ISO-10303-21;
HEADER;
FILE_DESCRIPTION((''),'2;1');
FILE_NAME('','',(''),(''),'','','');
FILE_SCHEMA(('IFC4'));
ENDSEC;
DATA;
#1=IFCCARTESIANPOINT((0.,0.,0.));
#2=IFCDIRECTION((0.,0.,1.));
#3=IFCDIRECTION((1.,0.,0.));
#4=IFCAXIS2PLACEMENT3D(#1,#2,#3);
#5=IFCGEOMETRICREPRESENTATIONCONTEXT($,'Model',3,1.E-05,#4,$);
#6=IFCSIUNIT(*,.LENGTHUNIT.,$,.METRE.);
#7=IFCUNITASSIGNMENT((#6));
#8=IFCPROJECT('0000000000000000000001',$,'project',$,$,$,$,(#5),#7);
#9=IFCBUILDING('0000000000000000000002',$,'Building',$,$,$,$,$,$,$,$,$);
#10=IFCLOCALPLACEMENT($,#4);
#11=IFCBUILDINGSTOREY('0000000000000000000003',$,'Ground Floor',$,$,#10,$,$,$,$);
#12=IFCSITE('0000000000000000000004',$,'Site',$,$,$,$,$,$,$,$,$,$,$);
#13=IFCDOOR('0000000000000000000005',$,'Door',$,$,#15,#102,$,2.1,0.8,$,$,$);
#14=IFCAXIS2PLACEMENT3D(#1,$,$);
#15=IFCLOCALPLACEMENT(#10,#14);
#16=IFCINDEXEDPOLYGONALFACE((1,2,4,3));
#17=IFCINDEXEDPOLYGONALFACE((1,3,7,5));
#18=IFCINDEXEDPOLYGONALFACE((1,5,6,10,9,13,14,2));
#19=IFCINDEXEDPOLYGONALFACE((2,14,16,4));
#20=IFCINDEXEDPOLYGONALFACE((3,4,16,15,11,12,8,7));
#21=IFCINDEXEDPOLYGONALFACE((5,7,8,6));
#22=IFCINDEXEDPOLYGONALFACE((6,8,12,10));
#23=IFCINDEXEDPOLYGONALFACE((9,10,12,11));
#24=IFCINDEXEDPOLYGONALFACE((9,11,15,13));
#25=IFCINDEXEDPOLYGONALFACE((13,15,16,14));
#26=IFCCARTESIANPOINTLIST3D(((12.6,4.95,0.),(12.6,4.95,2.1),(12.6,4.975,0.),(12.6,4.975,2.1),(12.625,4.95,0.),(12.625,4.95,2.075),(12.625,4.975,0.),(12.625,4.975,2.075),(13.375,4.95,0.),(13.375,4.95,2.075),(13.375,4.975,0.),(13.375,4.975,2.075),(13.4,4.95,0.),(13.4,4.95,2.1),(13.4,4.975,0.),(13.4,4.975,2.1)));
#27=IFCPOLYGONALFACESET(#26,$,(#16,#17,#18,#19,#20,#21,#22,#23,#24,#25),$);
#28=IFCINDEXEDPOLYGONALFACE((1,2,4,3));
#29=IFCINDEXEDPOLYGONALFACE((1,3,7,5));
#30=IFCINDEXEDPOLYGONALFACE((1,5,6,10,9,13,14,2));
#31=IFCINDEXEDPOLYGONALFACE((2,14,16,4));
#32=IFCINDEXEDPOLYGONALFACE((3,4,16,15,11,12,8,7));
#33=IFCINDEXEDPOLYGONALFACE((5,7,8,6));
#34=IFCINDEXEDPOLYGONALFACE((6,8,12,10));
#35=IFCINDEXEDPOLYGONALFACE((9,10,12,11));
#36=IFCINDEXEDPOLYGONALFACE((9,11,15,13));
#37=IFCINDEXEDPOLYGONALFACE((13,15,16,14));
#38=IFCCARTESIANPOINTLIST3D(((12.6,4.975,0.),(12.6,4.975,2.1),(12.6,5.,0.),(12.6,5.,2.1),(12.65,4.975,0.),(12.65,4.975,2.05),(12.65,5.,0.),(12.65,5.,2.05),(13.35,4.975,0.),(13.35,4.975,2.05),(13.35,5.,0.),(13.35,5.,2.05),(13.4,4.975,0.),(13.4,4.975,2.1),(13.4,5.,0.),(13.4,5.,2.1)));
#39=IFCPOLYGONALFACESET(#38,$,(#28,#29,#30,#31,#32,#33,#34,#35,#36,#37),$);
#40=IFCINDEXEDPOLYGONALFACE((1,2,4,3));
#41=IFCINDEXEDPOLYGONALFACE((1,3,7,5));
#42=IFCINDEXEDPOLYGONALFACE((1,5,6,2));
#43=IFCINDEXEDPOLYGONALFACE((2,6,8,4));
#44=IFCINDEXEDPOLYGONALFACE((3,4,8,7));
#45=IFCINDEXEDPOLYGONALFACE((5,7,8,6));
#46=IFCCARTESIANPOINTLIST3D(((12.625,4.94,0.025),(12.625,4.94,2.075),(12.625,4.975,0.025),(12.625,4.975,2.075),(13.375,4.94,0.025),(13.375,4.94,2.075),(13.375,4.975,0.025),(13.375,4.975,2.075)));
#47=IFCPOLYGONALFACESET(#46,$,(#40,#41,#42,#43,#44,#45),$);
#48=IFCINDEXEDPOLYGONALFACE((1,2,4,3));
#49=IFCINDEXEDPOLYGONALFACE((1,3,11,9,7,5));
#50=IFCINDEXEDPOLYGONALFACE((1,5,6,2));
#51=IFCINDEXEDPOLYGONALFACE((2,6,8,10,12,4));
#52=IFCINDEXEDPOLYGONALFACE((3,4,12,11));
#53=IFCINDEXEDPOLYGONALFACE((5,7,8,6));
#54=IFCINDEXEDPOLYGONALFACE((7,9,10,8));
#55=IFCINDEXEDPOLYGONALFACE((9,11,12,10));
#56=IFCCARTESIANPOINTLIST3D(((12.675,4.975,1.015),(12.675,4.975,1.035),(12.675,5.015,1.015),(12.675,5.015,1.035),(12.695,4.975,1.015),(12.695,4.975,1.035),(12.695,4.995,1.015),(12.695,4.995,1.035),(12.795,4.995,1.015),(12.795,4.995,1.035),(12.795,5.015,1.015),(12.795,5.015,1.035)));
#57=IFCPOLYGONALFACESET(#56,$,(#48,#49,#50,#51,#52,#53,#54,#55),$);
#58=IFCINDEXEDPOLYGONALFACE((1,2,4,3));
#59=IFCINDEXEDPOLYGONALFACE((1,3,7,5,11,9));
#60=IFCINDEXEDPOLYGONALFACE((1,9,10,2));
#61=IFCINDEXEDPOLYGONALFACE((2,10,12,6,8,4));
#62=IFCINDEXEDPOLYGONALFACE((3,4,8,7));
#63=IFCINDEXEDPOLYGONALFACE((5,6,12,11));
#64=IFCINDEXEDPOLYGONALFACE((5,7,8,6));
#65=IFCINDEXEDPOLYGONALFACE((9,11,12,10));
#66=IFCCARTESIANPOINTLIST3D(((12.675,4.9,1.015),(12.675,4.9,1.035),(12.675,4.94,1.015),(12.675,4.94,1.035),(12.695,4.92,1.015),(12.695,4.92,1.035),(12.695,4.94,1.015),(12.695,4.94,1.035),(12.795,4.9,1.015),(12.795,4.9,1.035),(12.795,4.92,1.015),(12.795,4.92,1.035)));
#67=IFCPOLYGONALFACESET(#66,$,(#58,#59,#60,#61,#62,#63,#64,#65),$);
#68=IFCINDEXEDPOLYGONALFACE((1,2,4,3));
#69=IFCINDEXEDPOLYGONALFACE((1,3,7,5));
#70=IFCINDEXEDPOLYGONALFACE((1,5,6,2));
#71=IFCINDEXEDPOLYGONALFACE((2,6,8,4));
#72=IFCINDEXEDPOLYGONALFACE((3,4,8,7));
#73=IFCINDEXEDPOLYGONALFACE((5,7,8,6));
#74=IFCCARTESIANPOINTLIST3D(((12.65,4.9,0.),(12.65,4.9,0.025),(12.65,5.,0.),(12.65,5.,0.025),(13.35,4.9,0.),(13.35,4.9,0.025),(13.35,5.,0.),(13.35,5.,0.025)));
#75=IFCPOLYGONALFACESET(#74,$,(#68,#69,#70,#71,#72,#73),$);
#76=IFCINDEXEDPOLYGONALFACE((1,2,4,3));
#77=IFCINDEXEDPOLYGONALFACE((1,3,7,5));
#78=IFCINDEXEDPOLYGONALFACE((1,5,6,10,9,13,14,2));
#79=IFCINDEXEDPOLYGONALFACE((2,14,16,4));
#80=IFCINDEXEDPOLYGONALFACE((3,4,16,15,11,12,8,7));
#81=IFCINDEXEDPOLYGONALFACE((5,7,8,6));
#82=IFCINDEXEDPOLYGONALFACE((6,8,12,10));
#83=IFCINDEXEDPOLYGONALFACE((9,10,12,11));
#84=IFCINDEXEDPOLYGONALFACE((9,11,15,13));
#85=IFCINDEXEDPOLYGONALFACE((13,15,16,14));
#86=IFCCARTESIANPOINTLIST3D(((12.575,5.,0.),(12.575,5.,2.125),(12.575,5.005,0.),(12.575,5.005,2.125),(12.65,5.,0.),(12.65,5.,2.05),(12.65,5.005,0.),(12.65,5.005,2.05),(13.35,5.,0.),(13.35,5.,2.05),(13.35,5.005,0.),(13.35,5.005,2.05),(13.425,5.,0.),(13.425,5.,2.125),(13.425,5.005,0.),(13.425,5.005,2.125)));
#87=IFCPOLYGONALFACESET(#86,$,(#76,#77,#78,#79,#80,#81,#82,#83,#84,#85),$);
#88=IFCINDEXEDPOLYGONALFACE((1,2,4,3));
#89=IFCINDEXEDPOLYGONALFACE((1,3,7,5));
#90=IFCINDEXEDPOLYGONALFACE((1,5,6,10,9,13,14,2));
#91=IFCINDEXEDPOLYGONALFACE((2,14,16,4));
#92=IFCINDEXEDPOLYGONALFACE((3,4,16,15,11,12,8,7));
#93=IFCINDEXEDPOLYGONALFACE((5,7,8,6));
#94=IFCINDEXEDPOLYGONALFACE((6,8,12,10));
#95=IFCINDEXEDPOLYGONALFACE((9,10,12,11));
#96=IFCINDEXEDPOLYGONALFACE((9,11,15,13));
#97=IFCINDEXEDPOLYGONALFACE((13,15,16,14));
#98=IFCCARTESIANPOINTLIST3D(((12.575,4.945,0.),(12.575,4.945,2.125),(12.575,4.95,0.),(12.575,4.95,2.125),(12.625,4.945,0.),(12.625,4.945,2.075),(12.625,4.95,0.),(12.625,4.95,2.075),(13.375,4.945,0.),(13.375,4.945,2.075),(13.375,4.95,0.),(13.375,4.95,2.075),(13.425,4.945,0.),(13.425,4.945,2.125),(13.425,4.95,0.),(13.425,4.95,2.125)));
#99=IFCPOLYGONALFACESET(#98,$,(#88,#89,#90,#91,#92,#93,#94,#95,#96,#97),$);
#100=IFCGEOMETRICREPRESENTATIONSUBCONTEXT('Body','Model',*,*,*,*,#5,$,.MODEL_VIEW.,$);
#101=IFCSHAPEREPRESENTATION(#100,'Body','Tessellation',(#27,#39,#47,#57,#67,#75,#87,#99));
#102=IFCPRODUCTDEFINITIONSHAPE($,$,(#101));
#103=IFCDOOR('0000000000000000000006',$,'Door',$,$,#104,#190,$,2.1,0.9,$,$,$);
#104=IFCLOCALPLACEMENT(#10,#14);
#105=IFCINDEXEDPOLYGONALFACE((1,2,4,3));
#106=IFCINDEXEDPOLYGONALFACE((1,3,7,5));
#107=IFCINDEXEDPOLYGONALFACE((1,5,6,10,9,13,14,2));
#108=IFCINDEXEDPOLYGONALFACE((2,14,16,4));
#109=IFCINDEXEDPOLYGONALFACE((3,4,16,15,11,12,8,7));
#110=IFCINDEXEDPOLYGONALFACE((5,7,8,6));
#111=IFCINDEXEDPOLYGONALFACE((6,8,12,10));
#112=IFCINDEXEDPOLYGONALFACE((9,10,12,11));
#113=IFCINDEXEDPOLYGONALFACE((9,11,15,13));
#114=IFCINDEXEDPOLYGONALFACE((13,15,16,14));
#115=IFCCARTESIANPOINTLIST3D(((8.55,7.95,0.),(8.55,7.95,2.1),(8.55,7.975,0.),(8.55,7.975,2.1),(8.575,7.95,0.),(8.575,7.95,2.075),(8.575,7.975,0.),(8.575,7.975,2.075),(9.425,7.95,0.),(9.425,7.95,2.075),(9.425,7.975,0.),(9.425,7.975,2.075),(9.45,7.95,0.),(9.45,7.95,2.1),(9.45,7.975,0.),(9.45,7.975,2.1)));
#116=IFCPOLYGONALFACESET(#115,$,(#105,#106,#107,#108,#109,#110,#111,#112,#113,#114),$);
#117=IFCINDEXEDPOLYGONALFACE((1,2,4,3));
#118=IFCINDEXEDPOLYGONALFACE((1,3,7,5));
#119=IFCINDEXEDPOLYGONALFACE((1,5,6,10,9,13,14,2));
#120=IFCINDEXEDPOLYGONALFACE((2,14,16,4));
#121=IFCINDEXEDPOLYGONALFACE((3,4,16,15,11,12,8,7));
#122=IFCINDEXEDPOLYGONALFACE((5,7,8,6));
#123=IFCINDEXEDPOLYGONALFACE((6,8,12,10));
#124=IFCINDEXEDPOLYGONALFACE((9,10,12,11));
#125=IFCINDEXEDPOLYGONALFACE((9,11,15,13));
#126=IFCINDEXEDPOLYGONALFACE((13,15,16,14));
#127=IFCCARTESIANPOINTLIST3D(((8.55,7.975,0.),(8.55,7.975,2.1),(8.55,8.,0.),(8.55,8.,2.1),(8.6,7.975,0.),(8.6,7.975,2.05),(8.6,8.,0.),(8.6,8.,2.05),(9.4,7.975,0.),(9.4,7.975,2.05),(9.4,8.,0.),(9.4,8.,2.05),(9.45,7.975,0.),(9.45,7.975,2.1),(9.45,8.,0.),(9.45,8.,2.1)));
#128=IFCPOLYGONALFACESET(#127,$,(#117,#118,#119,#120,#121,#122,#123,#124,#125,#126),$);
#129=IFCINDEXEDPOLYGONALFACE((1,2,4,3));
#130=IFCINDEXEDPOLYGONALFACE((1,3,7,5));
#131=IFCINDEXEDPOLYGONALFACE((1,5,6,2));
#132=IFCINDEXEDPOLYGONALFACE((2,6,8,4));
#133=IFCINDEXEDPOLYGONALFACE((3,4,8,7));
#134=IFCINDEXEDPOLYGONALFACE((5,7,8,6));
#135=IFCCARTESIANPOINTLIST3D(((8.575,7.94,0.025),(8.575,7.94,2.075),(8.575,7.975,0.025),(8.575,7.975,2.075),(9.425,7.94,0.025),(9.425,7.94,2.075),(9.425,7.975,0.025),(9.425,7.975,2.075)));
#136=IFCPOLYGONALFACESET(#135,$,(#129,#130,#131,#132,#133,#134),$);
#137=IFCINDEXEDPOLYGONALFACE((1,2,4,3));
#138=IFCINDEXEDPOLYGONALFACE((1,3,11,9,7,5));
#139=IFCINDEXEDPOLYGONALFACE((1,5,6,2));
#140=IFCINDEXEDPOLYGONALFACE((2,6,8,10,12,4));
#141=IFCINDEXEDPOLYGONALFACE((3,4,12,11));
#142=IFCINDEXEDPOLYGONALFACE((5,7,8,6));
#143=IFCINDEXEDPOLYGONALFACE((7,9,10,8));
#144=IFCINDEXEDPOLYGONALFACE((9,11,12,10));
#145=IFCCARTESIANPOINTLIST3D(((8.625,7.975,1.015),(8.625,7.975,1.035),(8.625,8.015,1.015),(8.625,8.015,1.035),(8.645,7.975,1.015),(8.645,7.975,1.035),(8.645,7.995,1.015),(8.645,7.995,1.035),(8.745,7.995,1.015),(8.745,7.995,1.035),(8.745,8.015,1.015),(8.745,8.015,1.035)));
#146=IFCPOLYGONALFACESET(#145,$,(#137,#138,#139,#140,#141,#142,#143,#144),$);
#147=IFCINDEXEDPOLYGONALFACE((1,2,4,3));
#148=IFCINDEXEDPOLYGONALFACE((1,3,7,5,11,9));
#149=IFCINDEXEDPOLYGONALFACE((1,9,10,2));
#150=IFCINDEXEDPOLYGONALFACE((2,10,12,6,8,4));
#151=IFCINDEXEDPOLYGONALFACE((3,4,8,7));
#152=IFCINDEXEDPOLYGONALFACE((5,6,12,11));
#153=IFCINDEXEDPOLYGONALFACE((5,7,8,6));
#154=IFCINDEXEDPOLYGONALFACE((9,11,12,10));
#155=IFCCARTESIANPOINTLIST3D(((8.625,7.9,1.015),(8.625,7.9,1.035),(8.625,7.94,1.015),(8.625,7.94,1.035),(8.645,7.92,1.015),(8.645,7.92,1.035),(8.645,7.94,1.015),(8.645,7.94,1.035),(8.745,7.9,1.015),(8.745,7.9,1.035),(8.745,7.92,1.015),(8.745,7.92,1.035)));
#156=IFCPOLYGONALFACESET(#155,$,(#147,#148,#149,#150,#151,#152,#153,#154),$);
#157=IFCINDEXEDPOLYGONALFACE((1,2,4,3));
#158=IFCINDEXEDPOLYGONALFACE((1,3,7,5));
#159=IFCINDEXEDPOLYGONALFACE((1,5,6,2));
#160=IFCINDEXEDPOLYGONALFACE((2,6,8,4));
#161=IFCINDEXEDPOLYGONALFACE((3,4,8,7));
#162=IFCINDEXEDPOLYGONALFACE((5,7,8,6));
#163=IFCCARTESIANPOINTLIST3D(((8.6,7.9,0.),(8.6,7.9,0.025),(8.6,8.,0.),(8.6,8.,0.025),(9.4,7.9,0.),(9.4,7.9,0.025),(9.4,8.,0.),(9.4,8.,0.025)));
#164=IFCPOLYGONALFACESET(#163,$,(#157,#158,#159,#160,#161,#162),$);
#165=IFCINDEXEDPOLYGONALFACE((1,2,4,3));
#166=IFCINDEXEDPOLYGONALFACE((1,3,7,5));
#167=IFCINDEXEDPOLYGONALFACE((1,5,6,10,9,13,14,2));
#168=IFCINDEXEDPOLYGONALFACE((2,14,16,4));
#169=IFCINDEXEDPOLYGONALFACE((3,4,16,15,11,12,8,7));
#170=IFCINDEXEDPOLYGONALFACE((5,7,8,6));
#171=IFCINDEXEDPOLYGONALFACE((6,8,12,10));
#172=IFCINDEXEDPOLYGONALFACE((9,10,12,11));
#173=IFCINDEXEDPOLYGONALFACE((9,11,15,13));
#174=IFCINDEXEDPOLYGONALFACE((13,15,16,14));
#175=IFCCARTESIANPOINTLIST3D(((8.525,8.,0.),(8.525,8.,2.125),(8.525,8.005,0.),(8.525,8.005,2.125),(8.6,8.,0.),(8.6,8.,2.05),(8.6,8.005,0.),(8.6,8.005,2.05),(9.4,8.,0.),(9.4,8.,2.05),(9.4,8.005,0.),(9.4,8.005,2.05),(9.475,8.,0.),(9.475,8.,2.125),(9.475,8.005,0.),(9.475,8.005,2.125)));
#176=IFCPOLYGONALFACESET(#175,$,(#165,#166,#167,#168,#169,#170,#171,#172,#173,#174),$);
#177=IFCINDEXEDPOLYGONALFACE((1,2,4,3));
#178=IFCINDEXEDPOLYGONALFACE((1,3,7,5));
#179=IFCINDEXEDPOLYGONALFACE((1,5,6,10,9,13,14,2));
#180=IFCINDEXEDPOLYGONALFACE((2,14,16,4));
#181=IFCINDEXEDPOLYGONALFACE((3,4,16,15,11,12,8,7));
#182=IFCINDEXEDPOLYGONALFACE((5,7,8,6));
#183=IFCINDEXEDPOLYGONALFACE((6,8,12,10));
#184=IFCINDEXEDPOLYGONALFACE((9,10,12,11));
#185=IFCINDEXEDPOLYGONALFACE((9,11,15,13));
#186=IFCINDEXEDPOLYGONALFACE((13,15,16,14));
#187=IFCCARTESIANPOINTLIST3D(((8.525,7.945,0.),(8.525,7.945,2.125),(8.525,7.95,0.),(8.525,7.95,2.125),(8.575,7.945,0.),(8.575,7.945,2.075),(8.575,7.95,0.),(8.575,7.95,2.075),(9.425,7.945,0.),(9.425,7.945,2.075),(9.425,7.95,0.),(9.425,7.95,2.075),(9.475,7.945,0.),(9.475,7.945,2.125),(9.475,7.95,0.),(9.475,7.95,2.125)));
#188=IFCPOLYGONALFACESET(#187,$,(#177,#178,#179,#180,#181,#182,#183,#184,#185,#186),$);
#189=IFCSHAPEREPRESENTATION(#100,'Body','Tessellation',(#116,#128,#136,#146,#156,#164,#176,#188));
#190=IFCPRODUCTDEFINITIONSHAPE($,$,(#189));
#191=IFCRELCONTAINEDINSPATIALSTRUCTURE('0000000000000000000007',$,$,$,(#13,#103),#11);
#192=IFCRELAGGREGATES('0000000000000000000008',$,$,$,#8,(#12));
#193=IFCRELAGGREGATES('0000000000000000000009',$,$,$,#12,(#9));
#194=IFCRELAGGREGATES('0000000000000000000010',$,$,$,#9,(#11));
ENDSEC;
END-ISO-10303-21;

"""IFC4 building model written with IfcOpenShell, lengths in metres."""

from ifc_helpers import new_model, si_unit, frame, origin_with_axes, place, context, subcontext, project, spatial, line, indexed_curve, outline, extrude, element, save


model = new_model("IFC4")

# Units and contexts
model_context = context("Model", 3, precision=1e-05, world=origin_with_axes())
body_context = subcontext(model_context, "Body", "Model", "MODEL_VIEW")
ifc_project = project(units=[si_unit("LENGTHUNIT", "METRE")], contexts=[model_context])

# Site, building, storey
site = spatial("IfcSite", under=ifc_project, Name="Site")
building = spatial("IfcBuilding", under=site, Name="Building")
storey_placement = place(None, origin_with_axes())
storey = spatial("IfcBuildingStorey", under=building, at=storey_placement, Name="Ground Floor")

# Doors
door_1_placement = place(storey_placement, frame((13.4, 5.0, 0.0), z_axis=(0.0, 0.0, 1.0), x_axis=(-1.0, 0.0, 0.0)))
element("IfcDoor", 1, at=door_1_placement, inside=storey, Name="Door", OverallHeight=2.1, OverallWidth=0.8, context=body_context, shape_type="SweptSolid", body=[
    extrude(outline(indexed_curve([(0.0, 0.0), (0.0, 2.1), (0.8, 2.1), (0.8, 0.0), (0.775, 0.0), (0.775, 2.075), (0.025, 2.075), (0.025, 0.0)], segments=[line(1, 2, 3, 4, 5, 6, 7, 8, 1)])), frame((0.0, 0.025, 0.0), z_axis=(0.0, -1.0, 0.0), x_axis=(1.0, 0.0, 0.0)), (0.0, 0.0, -1.0), 0.025),
    extrude(outline(indexed_curve([(0.0, 0.0), (0.0, 2.1), (0.8, 2.1), (0.8, 0.0), (0.75, 0.0), (0.75, 2.05), (0.05, 2.05), (0.05, 0.0)], segments=[line(1, 2, 3, 4, 5, 6, 7, 8, 1)])), frame((0.0, 0.0, 0.0), z_axis=(0.0, -1.0, 0.0), x_axis=(1.0, 0.0, 0.0)), (0.0, 0.0, -1.0), 0.025),
    extrude(outline(indexed_curve([(0.0, 0.0), (0.75, 0.0), (0.75, 0.035), (0.0, 0.035)], segments=[line(1, 2, 3, 4, 1)])), frame((0.025, 0.025, 0.025), z_axis=(0.0, 0.0, 1.0), x_axis=(1.0, 0.0, 0.0)), (0.0, 0.0, 1.0), 2.05),
    extrude(outline(indexed_curve([(0.0, 0.0), (0.0, -0.04), (-0.12, -0.04), (-0.12, -0.02), (-0.02, -0.02), (-0.02, 0.0)], segments=[line(1, 2, 3, 4, 5, 6, 1)])), frame((0.725, 0.025, 1.015), z_axis=(0.0, 0.0, 1.0), x_axis=(1.0, 0.0, 0.0)), (0.0, 0.0, 1.0), 0.02),
    extrude(outline(indexed_curve([(0.0, 0.0), (0.0, 0.04), (-0.12, 0.04), (-0.12, 0.02), (-0.02, 0.02), (-0.02, 0.0)], segments=[line(1, 2, 3, 4, 5, 6, 1)])), frame((0.725, 0.06, 1.015), z_axis=(0.0, 0.0, 1.0), x_axis=(1.0, 0.0, 0.0)), (0.0, 0.0, 1.0), 0.02),
    extrude(outline(indexed_curve([(0.0, 0.0), (0.7, 0.0), (0.7, 0.1), (0.0, 0.1)], segments=[line(1, 2, 3, 4, 1)])), frame((0.05, 0.0, 0.0), z_axis=(0.0, 0.0, 1.0), x_axis=(1.0, 0.0, 0.0)), (0.0, 0.0, 1.0), 0.025),
    extrude(outline(indexed_curve([(0.0, 0.0), (0.0, 2.125), (0.85, 2.125), (0.85, 0.0), (0.775, 0.0), (0.775, 2.05), (0.075, 2.05), (0.075, 0.0)], segments=[line(1, 2, 3, 4, 5, 6, 7, 8, 1)])), frame((-0.025, -0.005, 0.0), z_axis=(0.0, -1.0, 0.0), x_axis=(1.0, 0.0, 0.0)), (0.0, 0.0, -1.0), 0.005),
    extrude(outline(indexed_curve([(0.0, 0.0), (0.0, 2.125), (0.85, 2.125), (0.85, 0.0), (0.8, 0.0), (0.8, 2.075), (0.05, 2.075), (0.05, 0.0)], segments=[line(1, 2, 3, 4, 5, 6, 7, 8, 1)])), frame((-0.025, 0.05, 0.0), z_axis=(0.0, -1.0, 0.0), x_axis=(1.0, 0.0, 0.0)), (0.0, 0.0, -1.0), 0.005),
])
door_2_placement = place(storey_placement, frame((9.45, 8.0, 0.0), z_axis=(0.0, 0.0, 1.0), x_axis=(-1.0, 0.0, 0.0)))
element("IfcDoor", 2, at=door_2_placement, inside=storey, Name="Door", OverallHeight=2.1, OverallWidth=0.9, context=body_context, shape_type="SweptSolid", body=[
    extrude(outline(indexed_curve([(0.0, 0.0), (0.0, 2.1), (0.9, 2.1), (0.9, 0.0), (0.875, 0.0), (0.875, 2.075), (0.025, 2.075), (0.025, 0.0)], segments=[line(1, 2, 3, 4, 5, 6, 7, 8, 1)])), frame((0.0, 0.025, 0.0), z_axis=(0.0, -1.0, 0.0), x_axis=(1.0, 0.0, 0.0)), (0.0, 0.0, -1.0), 0.025),
    extrude(outline(indexed_curve([(0.0, 0.0), (0.0, 2.1), (0.9, 2.1), (0.9, 0.0), (0.85, 0.0), (0.85, 2.05), (0.05, 2.05), (0.05, 0.0)], segments=[line(1, 2, 3, 4, 5, 6, 7, 8, 1)])), frame((0.0, 0.0, 0.0), z_axis=(0.0, -1.0, 0.0), x_axis=(1.0, 0.0, 0.0)), (0.0, 0.0, -1.0), 0.025),
    extrude(outline(indexed_curve([(0.0, 0.0), (0.85, 0.0), (0.85, 0.035), (0.0, 0.035)], segments=[line(1, 2, 3, 4, 1)])), frame((0.025, 0.025, 0.025), z_axis=(0.0, 0.0, 1.0), x_axis=(1.0, 0.0, 0.0)), (0.0, 0.0, 1.0), 2.05),
    extrude(outline(indexed_curve([(0.0, 0.0), (0.0, -0.04), (-0.12, -0.04), (-0.12, -0.02), (-0.02, -0.02), (-0.02, 0.0)], segments=[line(1, 2, 3, 4, 5, 6, 1)])), frame((0.825, 0.025, 1.015), z_axis=(0.0, 0.0, 1.0), x_axis=(1.0, 0.0, 0.0)), (0.0, 0.0, 1.0), 0.02),
    extrude(outline(indexed_curve([(0.0, 0.0), (0.0, 0.04), (-0.12, 0.04), (-0.12, 0.02), (-0.02, 0.02), (-0.02, 0.0)], segments=[line(1, 2, 3, 4, 5, 6, 1)])), frame((0.825, 0.06, 1.015), z_axis=(0.0, 0.0, 1.0), x_axis=(1.0, 0.0, 0.0)), (0.0, 0.0, 1.0), 0.02),
    extrude(outline(indexed_curve([(0.0, 0.0), (0.8, 0.0), (0.8, 0.1), (0.0, 0.1)], segments=[line(1, 2, 3, 4, 1)])), frame((0.05, 0.0, 0.0), z_axis=(0.0, 0.0, 1.0), x_axis=(1.0, 0.0, 0.0)), (0.0, 0.0, 1.0), 0.025),
    extrude(outline(indexed_curve([(0.0, 0.0), (0.0, 2.125), (0.95, 2.125), (0.95, 0.0), (0.875, 0.0), (0.875, 2.05), (0.075, 2.05), (0.075, 0.0)], segments=[line(1, 2, 3, 4, 5, 6, 7, 8, 1)])), frame((-0.025, -0.005, 0.0), z_axis=(0.0, -1.0, 0.0), x_axis=(1.0, 0.0, 0.0)), (0.0, 0.0, -1.0), 0.005),
    extrude(outline(indexed_curve([(0.0, 0.0), (0.0, 2.125), (0.95, 2.125), (0.95, 0.0), (0.9, 0.0), (0.9, 2.075), (0.05, 2.075), (0.05, 0.0)], segments=[line(1, 2, 3, 4, 5, 6, 7, 8, 1)])), frame((-0.025, 0.05, 0.0), z_axis=(0.0, -1.0, 0.0), x_axis=(1.0, 0.0, 0.0)), (0.0, 0.0, -1.0), 0.005),
])

save(model, "model.ifc")
